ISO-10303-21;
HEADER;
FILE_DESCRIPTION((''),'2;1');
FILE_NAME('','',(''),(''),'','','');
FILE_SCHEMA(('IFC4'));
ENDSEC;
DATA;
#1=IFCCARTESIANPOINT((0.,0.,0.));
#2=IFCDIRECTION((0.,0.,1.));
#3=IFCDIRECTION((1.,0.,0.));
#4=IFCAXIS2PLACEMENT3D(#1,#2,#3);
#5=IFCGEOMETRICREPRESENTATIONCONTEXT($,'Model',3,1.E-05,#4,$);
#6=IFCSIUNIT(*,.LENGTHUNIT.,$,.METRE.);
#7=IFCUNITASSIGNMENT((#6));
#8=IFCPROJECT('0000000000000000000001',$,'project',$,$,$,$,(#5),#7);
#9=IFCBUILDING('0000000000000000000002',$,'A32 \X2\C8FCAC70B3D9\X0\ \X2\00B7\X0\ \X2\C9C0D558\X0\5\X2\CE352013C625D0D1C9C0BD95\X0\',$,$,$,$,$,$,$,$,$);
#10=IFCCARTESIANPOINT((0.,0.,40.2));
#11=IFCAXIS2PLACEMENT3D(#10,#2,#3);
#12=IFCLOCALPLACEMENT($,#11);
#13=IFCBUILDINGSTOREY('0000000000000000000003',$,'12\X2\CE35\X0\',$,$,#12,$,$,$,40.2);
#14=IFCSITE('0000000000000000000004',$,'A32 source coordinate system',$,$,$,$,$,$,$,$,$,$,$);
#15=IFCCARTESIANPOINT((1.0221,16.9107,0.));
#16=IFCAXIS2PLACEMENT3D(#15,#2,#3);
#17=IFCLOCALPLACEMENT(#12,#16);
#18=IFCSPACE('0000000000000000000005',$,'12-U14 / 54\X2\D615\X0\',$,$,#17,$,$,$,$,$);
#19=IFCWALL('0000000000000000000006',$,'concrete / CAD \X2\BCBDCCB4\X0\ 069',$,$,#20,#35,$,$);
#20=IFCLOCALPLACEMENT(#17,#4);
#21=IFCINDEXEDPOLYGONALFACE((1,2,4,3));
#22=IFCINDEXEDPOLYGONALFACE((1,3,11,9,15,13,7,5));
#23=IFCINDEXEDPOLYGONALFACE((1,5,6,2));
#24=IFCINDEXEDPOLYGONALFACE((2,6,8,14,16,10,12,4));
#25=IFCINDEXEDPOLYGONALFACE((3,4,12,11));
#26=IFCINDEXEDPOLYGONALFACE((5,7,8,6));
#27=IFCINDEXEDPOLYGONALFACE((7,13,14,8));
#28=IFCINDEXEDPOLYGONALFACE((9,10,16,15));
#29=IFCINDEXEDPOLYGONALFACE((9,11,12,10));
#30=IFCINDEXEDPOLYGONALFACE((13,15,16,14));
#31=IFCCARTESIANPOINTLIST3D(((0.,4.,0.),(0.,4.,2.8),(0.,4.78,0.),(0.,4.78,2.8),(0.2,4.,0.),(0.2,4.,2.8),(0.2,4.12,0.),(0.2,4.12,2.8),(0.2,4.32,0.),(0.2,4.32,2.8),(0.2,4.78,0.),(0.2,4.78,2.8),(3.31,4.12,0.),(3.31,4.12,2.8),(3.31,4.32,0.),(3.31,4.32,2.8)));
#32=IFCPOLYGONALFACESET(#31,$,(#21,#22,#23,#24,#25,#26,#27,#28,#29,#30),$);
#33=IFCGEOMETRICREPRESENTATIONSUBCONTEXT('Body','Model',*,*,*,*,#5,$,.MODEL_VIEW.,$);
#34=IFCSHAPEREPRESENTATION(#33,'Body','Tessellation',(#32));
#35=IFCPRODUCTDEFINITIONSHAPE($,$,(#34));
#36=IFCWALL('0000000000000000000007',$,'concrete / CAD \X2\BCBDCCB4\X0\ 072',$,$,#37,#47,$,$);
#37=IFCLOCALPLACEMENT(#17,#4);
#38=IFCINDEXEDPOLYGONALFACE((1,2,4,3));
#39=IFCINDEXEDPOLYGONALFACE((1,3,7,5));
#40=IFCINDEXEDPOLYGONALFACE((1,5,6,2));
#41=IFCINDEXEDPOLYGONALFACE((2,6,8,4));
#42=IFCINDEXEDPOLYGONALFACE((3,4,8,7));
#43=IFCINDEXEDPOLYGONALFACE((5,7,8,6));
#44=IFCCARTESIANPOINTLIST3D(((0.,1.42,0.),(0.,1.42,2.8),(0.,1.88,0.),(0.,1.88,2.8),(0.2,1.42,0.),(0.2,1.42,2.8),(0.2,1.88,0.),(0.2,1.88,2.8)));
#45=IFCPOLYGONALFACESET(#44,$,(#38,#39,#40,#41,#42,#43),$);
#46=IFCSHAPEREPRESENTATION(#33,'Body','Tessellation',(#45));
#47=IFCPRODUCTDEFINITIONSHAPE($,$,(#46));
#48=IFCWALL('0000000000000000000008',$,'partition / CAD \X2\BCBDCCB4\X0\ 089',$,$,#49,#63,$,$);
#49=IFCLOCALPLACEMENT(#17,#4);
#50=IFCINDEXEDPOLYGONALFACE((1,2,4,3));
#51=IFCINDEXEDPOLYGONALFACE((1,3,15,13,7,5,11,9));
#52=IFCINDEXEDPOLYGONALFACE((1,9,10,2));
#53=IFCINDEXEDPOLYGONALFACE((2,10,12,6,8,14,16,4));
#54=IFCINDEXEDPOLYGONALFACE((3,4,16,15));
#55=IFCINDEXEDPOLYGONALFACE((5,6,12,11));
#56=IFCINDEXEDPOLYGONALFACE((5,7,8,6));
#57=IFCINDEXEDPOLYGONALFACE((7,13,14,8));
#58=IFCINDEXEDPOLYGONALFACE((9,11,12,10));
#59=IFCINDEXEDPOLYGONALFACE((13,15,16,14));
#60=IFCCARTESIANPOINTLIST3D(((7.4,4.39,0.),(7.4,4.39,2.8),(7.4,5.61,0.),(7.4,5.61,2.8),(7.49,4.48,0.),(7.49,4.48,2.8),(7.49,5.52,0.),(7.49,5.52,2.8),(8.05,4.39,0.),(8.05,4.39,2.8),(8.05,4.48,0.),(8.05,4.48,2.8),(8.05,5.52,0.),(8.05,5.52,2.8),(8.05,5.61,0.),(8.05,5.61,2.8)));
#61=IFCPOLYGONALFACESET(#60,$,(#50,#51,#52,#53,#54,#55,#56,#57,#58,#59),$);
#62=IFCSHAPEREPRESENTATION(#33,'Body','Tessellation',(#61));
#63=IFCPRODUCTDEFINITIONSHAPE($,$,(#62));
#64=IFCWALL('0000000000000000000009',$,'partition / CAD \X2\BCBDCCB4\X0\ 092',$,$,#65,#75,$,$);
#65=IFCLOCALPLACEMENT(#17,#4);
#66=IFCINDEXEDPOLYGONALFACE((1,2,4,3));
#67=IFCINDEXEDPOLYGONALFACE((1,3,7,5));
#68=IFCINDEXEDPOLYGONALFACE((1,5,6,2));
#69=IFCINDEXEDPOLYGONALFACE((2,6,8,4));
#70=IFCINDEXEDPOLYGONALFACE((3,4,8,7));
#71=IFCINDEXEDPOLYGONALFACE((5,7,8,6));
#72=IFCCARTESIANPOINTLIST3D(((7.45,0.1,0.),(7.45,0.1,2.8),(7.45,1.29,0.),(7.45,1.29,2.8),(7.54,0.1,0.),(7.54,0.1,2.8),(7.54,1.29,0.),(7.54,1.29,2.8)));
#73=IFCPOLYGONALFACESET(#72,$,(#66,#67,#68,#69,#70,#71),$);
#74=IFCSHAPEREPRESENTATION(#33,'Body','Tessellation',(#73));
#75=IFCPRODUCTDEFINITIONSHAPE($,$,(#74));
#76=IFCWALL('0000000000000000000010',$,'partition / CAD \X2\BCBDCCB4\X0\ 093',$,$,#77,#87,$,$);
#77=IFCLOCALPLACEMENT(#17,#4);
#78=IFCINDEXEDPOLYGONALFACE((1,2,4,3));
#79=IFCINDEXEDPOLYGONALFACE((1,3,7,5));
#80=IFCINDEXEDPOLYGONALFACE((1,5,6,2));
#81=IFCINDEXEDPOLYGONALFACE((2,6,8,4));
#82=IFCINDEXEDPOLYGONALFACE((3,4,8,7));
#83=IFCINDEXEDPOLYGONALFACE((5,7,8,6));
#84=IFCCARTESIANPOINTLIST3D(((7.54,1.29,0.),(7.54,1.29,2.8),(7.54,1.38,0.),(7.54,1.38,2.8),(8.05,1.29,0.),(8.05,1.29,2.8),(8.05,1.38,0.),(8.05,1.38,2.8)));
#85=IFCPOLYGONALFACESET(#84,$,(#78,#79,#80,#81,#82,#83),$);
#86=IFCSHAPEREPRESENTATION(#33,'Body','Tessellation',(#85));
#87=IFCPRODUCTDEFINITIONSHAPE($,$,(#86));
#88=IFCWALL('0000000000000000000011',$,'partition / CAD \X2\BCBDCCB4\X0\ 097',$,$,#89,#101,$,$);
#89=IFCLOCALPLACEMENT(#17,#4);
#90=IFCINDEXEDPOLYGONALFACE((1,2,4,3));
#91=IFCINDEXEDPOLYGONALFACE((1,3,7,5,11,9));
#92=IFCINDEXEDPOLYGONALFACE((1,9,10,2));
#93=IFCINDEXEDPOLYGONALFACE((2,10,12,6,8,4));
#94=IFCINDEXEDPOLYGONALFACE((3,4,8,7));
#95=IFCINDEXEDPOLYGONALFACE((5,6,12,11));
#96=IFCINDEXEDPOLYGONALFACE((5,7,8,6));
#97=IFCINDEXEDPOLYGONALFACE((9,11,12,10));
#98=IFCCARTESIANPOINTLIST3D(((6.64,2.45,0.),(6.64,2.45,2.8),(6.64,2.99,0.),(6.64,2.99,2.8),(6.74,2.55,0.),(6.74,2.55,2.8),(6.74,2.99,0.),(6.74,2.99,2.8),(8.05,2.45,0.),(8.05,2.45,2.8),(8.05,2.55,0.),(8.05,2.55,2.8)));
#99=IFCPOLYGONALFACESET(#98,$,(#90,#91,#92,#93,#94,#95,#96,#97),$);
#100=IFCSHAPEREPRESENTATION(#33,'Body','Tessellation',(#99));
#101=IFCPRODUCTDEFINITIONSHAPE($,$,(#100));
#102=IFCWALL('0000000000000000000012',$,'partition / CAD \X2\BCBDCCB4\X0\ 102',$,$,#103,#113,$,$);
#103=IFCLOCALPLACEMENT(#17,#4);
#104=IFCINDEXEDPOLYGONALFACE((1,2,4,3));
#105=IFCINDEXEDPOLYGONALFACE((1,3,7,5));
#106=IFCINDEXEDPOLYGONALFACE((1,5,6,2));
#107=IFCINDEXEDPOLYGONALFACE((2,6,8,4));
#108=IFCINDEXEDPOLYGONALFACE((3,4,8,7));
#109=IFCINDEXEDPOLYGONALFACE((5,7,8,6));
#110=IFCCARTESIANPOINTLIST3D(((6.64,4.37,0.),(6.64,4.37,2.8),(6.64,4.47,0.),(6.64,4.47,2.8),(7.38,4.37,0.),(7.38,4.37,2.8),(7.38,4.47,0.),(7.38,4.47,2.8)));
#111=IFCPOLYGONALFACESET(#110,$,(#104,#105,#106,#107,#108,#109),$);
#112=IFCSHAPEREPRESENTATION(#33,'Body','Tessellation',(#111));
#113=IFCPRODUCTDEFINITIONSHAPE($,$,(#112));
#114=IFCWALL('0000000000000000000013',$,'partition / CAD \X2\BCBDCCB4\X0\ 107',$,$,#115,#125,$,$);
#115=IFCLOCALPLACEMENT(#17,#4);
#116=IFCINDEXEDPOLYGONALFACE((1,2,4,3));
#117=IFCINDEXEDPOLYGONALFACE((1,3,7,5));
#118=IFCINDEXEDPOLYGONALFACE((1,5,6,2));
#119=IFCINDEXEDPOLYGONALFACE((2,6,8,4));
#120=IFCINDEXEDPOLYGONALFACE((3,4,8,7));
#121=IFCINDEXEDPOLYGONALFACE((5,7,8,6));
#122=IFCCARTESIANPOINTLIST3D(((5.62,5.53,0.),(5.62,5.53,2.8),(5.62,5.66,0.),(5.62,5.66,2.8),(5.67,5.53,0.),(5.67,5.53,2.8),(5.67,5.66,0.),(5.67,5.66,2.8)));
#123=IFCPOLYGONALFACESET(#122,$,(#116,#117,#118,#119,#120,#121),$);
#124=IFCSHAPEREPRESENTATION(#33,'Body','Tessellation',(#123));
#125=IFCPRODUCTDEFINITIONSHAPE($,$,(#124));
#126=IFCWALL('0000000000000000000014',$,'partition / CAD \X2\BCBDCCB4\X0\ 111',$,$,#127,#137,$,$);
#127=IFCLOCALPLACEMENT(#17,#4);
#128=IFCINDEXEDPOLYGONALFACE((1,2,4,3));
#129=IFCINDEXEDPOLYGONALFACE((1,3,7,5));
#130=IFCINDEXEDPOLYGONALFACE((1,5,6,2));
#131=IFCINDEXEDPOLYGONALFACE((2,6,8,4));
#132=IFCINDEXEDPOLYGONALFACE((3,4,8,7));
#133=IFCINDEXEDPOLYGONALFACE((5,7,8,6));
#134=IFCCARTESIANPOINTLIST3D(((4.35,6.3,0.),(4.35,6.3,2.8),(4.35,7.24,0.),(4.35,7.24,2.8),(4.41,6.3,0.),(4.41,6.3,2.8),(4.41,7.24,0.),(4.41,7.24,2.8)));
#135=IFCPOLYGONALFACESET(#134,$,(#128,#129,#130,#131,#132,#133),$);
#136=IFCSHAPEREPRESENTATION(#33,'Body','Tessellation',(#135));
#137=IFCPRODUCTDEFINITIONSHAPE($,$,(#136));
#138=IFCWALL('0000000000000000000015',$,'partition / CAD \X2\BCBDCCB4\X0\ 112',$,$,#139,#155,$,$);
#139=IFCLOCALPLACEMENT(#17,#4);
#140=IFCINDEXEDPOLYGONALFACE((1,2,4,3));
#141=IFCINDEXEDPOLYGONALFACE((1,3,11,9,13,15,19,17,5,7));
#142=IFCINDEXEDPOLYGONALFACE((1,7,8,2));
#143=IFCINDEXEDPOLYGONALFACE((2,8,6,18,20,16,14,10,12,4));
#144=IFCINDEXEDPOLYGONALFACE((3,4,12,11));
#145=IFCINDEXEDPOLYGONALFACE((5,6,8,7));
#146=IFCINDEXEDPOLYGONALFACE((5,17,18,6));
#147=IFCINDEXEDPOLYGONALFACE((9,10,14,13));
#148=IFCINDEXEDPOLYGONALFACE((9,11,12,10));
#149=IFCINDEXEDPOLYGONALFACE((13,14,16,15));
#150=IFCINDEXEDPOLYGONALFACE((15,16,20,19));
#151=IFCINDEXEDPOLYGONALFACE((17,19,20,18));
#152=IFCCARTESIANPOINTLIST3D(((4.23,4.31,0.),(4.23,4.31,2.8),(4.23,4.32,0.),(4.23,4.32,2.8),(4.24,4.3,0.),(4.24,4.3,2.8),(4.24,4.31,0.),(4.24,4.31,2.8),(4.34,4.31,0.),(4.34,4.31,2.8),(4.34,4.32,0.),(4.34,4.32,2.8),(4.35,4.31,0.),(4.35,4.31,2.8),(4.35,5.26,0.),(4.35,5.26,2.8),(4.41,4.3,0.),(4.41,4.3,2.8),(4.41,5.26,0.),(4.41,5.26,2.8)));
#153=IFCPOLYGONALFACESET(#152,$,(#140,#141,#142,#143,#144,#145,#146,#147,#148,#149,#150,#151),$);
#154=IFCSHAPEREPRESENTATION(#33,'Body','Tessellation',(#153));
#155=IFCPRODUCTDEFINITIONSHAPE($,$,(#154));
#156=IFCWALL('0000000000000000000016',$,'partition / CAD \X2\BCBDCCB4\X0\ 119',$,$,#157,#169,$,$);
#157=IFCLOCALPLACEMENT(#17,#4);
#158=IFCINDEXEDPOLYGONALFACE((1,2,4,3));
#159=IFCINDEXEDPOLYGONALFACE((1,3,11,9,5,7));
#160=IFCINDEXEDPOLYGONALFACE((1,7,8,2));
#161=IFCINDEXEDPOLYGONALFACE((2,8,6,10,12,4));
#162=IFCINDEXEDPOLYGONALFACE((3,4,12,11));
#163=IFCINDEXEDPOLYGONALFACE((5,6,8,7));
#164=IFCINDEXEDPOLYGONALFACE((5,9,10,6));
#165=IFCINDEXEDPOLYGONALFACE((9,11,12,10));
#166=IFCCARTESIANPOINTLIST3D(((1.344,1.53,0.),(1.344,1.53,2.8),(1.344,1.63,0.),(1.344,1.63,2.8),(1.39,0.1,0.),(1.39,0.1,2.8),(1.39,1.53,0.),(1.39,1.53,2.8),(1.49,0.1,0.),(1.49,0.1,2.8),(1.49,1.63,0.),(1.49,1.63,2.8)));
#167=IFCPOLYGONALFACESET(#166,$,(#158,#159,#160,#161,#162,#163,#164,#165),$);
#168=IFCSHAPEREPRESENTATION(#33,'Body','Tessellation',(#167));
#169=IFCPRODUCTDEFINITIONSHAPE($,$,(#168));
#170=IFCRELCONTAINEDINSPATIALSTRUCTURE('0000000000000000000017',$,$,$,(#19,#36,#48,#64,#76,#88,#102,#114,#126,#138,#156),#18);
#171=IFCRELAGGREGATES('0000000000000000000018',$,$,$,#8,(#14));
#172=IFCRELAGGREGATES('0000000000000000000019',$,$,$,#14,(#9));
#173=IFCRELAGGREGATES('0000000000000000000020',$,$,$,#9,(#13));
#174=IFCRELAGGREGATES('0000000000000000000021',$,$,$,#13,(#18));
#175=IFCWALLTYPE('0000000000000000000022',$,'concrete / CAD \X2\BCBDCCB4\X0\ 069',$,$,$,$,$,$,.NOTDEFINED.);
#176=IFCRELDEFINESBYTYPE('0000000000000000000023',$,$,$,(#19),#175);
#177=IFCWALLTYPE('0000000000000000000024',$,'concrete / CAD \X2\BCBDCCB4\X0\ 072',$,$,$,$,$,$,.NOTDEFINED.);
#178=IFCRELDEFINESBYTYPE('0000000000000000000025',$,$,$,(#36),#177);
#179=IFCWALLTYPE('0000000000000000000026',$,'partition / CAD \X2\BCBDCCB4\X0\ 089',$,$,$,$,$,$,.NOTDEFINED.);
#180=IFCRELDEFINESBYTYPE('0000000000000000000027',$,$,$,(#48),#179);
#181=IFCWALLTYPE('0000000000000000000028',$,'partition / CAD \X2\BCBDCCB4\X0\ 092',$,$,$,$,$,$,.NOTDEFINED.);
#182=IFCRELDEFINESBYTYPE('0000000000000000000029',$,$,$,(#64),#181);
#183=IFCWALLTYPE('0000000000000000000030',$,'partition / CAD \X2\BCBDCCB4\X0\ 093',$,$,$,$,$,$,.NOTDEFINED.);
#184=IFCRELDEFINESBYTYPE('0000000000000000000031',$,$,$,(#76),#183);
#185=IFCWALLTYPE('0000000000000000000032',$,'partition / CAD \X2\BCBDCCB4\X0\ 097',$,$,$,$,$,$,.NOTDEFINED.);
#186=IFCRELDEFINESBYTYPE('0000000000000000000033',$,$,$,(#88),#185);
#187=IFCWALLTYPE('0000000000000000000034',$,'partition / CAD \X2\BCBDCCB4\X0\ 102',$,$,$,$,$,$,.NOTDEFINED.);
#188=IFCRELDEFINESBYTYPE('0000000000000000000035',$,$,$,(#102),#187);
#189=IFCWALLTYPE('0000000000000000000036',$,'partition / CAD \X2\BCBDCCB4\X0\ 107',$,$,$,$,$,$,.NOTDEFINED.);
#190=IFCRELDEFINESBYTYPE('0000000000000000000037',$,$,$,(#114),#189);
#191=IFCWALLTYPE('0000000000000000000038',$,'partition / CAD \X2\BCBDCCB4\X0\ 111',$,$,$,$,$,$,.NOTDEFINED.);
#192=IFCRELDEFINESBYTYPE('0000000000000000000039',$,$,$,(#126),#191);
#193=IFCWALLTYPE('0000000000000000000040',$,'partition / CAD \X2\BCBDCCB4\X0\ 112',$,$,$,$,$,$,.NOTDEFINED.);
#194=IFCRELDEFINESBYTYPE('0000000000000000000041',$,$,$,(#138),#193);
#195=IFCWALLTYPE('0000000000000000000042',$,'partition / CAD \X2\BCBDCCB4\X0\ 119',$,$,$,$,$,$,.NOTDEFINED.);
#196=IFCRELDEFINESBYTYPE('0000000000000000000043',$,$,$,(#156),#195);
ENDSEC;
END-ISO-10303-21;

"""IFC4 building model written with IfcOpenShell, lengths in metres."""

from ifc_helpers import new_model, si_unit, frame, origin, origin_with_axes, place, context, subcontext, project, spatial, polyline, outline, extrude, source, transform, mapped, type_object, type_shapes, element, save


model = new_model("IFC4")

# Units and contexts
model_context = context("Model", 3, precision=1e-05, world=origin_with_axes())
body_context = subcontext(model_context, "Body", "Model", "MODEL_VIEW")
ifc_project = project(units=[si_unit("LENGTHUNIT", "METRE")], contexts=[model_context])

# Site, building, storey, space
site = spatial("IfcSite", under=ifc_project, Name="A32 source coordinate system")
building = spatial("IfcBuilding", under=site, Name="A32 주거동 · 지하5층–옥탑지붕")
storey_placement = place(None, frame((0.0, 0.0, 40.2), z_axis=(0.0, 0.0, 1.0), x_axis=(1.0, 0.0, 0.0)))
storey = spatial("IfcBuildingStorey", under=building, at=storey_placement, Name="12층", Elevation=40.2)
space_placement = place(storey_placement, frame((1.0221, 16.9107, 0.0), z_axis=(0.0, 0.0, 1.0), x_axis=(1.0, 0.0, 0.0)))
space = spatial("IfcSpace", under=storey, at=space_placement, Name="12-U14 / 54형")

# Walls
wall_type_1 = type_object("IfcWallType", Name="concrete / CAD 벽체 069", PredefinedType="NOTDEFINED")
shared_shape_1 = source(origin(), body_context, "Body", "SweptSolid", [
    extrude(outline(polyline([(0.2, 4.12), (0.2, 4.0), (0.0, 4.0), (0.0, 4.78), (0.2, 4.78), (0.2, 4.32), (3.31, 4.32), (3.31, 4.12), (0.2, 4.12)])), origin(), (0.0, 0.0, 1.0), 2.8),
])
type_shapes(wall_type_1, [shared_shape_1])
wall_1_placement = place(space_placement, origin_with_axes())
element("IfcWall", 1, at=wall_1_placement, inside=space, type_object=wall_type_1, Name="concrete / CAD 벽체 069", context=body_context, shape_type="MappedRepresentation", body=[
    mapped(shared_shape_1, transform((0.0, 0.0, 0.0), scale=1.0)),
])
wall_type_2 = type_object("IfcWallType", Name="concrete / CAD 벽체 072", PredefinedType="NOTDEFINED")
shared_shape_2 = source(origin(), body_context, "Body", "SweptSolid", [
    extrude(outline(polyline([(0.2, 1.88), (0.2, 1.42), (0.0, 1.42), (0.0, 1.88), (0.2, 1.88)])), origin(), (0.0, 0.0, 1.0), 2.8),
])
type_shapes(wall_type_2, [shared_shape_2])
wall_2_placement = place(space_placement, origin_with_axes())
element("IfcWall", 2, at=wall_2_placement, inside=space, type_object=wall_type_2, Name="concrete / CAD 벽체 072", context=body_context, shape_type="MappedRepresentation", body=[
    mapped(shared_shape_2, transform((0.0, 0.0, 0.0), scale=1.0)),
])
wall_type_3 = type_object("IfcWallType", Name="partition / CAD 벽체 089", PredefinedType="NOTDEFINED")
shared_shape_3 = source(origin(), body_context, "Body", "SweptSolid", [
    extrude(outline(polyline([(7.49, 4.48), (8.05, 4.48), (8.05, 4.39), (7.4, 4.39), (7.4, 5.61), (8.05, 5.61), (8.05, 5.52), (7.49, 5.52), (7.49, 4.48)])), origin(), (0.0, 0.0, 1.0), 2.8),
])
type_shapes(wall_type_3, [shared_shape_3])
wall_3_placement = place(space_placement, origin_with_axes())
element("IfcWall", 3, at=wall_3_placement, inside=space, type_object=wall_type_3, Name="partition / CAD 벽체 089", context=body_context, shape_type="MappedRepresentation", body=[
    mapped(shared_shape_3, transform((0.0, 0.0, 0.0), scale=1.0)),
])
wall_type_4 = type_object("IfcWallType", Name="partition / CAD 벽체 092", PredefinedType="NOTDEFINED")
shared_shape_4 = source(origin(), body_context, "Body", "SweptSolid", [
    extrude(outline(polyline([(7.54, 1.29), (7.54, 0.1), (7.45, 0.1), (7.45, 1.29), (7.54, 1.29)])), origin(), (0.0, 0.0, 1.0), 2.8),
])
type_shapes(wall_type_4, [shared_shape_4])
wall_4_placement = place(space_placement, origin_with_axes())
element("IfcWall", 4, at=wall_4_placement, inside=space, type_object=wall_type_4, Name="partition / CAD 벽체 092", context=body_context, shape_type="MappedRepresentation", body=[
    mapped(shared_shape_4, transform((0.0, 0.0, 0.0), scale=1.0)),
])
wall_type_5 = type_object("IfcWallType", Name="partition / CAD 벽체 093", PredefinedType="NOTDEFINED")
shared_shape_5 = source(origin(), body_context, "Body", "SweptSolid", [
    extrude(outline(polyline([(8.05, 1.29), (7.54, 1.29), (7.54, 1.38), (8.05, 1.38), (8.05, 1.29)])), origin(), (0.0, 0.0, 1.0), 2.8),
])
type_shapes(wall_type_5, [shared_shape_5])
wall_5_placement = place(space_placement, origin_with_axes())
element("IfcWall", 5, at=wall_5_placement, inside=space, type_object=wall_type_5, Name="partition / CAD 벽체 093", context=body_context, shape_type="MappedRepresentation", body=[
    mapped(shared_shape_5, transform((0.0, 0.0, 0.0), scale=1.0)),
])
wall_type_6 = type_object("IfcWallType", Name="partition / CAD 벽체 097", PredefinedType="NOTDEFINED")
shared_shape_6 = source(origin(), body_context, "Body", "SweptSolid", [
    extrude(outline(polyline([(8.05, 2.45), (6.64, 2.45), (6.64, 2.99), (6.74, 2.99), (6.74, 2.55), (8.05, 2.55), (8.05, 2.45)])), origin(), (0.0, 0.0, 1.0), 2.8),
])
type_shapes(wall_type_6, [shared_shape_6])
wall_6_placement = place(space_placement, origin_with_axes())
element("IfcWall", 6, at=wall_6_placement, inside=space, type_object=wall_type_6, Name="partition / CAD 벽체 097", context=body_context, shape_type="MappedRepresentation", body=[
    mapped(shared_shape_6, transform((0.0, 0.0, 0.0), scale=1.0)),
])
wall_type_7 = type_object("IfcWallType", Name="partition / CAD 벽체 102", PredefinedType="NOTDEFINED")
shared_shape_7 = source(origin(), body_context, "Body", "SweptSolid", [
    extrude(outline(polyline([(7.38, 4.47), (7.38, 4.37), (6.64, 4.37), (6.64, 4.47), (7.38, 4.47)])), origin(), (0.0, 0.0, 1.0), 2.8),
])
type_shapes(wall_type_7, [shared_shape_7])
wall_7_placement = place(space_placement, origin_with_axes())
element("IfcWall", 7, at=wall_7_placement, inside=space, type_object=wall_type_7, Name="partition / CAD 벽체 102", context=body_context, shape_type="MappedRepresentation", body=[
    mapped(shared_shape_7, transform((0.0, 0.0, 0.0), scale=1.0)),
])
wall_type_8 = type_object("IfcWallType", Name="partition / CAD 벽체 107", PredefinedType="NOTDEFINED")
shared_shape_8 = source(origin(), body_context, "Body", "SweptSolid", [
    extrude(outline(polyline([(5.62, 5.53), (5.62, 5.66), (5.67, 5.66), (5.67, 5.53), (5.62, 5.53)])), origin(), (0.0, 0.0, 1.0), 2.8),
])
type_shapes(wall_type_8, [shared_shape_8])
wall_8_placement = place(space_placement, origin_with_axes())
element("IfcWall", 8, at=wall_8_placement, inside=space, type_object=wall_type_8, Name="partition / CAD 벽체 107", context=body_context, shape_type="MappedRepresentation", body=[
    mapped(shared_shape_8, transform((0.0, 0.0, 0.0), scale=1.0)),
])
wall_type_9 = type_object("IfcWallType", Name="partition / CAD 벽체 111", PredefinedType="NOTDEFINED")
shared_shape_9 = source(origin(), body_context, "Body", "SweptSolid", [
    extrude(outline(polyline([(4.41, 7.24), (4.41, 6.3), (4.35, 6.3), (4.35, 7.24), (4.41, 7.24)])), origin(), (0.0, 0.0, 1.0), 2.8),
])
type_shapes(wall_type_9, [shared_shape_9])
wall_9_placement = place(space_placement, origin_with_axes())
element("IfcWall", 9, at=wall_9_placement, inside=space, type_object=wall_type_9, Name="partition / CAD 벽체 111", context=body_context, shape_type="MappedRepresentation", body=[
    mapped(shared_shape_9, transform((0.0, 0.0, 0.0), scale=1.0)),
])
wall_type_10 = type_object("IfcWallType", Name="partition / CAD 벽체 112", PredefinedType="NOTDEFINED")
shared_shape_10 = source(origin(), body_context, "Body", "SweptSolid", [
    extrude(outline(polyline([(4.24, 4.3), (4.24, 4.31), (4.23, 4.31), (4.23, 4.32), (4.34, 4.32), (4.34, 4.31), (4.35, 4.31), (4.35, 5.26), (4.41, 5.26), (4.41, 4.3), (4.24, 4.3)])), origin(), (0.0, 0.0, 1.0), 2.8),
])
type_shapes(wall_type_10, [shared_shape_10])
wall_10_placement = place(space_placement, origin_with_axes())
element("IfcWall", 10, at=wall_10_placement, inside=space, type_object=wall_type_10, Name="partition / CAD 벽체 112", context=body_context, shape_type="MappedRepresentation", body=[
    mapped(shared_shape_10, transform((0.0, 0.0, 0.0), scale=1.0)),
])
wall_type_11 = type_object("IfcWallType", Name="partition / CAD 벽체 119", PredefinedType="NOTDEFINED")
shared_shape_11 = source(origin(), body_context, "Body", "SweptSolid", [
    extrude(outline(polyline([(1.344, 1.53), (1.344, 1.63), (1.49, 1.63), (1.49, 0.1), (1.39, 0.1), (1.39, 1.53), (1.344, 1.53)])), origin(), (0.0, 0.0, 1.0), 2.8),
])
type_shapes(wall_type_11, [shared_shape_11])
wall_11_placement = place(space_placement, origin_with_axes())
element("IfcWall", 11, at=wall_11_placement, inside=space, type_object=wall_type_11, Name="partition / CAD 벽체 119", context=body_context, shape_type="MappedRepresentation", body=[
    mapped(shared_shape_11, transform((0.0, 0.0, 0.0), scale=1.0)),
])

save(model, "model.ifc")
